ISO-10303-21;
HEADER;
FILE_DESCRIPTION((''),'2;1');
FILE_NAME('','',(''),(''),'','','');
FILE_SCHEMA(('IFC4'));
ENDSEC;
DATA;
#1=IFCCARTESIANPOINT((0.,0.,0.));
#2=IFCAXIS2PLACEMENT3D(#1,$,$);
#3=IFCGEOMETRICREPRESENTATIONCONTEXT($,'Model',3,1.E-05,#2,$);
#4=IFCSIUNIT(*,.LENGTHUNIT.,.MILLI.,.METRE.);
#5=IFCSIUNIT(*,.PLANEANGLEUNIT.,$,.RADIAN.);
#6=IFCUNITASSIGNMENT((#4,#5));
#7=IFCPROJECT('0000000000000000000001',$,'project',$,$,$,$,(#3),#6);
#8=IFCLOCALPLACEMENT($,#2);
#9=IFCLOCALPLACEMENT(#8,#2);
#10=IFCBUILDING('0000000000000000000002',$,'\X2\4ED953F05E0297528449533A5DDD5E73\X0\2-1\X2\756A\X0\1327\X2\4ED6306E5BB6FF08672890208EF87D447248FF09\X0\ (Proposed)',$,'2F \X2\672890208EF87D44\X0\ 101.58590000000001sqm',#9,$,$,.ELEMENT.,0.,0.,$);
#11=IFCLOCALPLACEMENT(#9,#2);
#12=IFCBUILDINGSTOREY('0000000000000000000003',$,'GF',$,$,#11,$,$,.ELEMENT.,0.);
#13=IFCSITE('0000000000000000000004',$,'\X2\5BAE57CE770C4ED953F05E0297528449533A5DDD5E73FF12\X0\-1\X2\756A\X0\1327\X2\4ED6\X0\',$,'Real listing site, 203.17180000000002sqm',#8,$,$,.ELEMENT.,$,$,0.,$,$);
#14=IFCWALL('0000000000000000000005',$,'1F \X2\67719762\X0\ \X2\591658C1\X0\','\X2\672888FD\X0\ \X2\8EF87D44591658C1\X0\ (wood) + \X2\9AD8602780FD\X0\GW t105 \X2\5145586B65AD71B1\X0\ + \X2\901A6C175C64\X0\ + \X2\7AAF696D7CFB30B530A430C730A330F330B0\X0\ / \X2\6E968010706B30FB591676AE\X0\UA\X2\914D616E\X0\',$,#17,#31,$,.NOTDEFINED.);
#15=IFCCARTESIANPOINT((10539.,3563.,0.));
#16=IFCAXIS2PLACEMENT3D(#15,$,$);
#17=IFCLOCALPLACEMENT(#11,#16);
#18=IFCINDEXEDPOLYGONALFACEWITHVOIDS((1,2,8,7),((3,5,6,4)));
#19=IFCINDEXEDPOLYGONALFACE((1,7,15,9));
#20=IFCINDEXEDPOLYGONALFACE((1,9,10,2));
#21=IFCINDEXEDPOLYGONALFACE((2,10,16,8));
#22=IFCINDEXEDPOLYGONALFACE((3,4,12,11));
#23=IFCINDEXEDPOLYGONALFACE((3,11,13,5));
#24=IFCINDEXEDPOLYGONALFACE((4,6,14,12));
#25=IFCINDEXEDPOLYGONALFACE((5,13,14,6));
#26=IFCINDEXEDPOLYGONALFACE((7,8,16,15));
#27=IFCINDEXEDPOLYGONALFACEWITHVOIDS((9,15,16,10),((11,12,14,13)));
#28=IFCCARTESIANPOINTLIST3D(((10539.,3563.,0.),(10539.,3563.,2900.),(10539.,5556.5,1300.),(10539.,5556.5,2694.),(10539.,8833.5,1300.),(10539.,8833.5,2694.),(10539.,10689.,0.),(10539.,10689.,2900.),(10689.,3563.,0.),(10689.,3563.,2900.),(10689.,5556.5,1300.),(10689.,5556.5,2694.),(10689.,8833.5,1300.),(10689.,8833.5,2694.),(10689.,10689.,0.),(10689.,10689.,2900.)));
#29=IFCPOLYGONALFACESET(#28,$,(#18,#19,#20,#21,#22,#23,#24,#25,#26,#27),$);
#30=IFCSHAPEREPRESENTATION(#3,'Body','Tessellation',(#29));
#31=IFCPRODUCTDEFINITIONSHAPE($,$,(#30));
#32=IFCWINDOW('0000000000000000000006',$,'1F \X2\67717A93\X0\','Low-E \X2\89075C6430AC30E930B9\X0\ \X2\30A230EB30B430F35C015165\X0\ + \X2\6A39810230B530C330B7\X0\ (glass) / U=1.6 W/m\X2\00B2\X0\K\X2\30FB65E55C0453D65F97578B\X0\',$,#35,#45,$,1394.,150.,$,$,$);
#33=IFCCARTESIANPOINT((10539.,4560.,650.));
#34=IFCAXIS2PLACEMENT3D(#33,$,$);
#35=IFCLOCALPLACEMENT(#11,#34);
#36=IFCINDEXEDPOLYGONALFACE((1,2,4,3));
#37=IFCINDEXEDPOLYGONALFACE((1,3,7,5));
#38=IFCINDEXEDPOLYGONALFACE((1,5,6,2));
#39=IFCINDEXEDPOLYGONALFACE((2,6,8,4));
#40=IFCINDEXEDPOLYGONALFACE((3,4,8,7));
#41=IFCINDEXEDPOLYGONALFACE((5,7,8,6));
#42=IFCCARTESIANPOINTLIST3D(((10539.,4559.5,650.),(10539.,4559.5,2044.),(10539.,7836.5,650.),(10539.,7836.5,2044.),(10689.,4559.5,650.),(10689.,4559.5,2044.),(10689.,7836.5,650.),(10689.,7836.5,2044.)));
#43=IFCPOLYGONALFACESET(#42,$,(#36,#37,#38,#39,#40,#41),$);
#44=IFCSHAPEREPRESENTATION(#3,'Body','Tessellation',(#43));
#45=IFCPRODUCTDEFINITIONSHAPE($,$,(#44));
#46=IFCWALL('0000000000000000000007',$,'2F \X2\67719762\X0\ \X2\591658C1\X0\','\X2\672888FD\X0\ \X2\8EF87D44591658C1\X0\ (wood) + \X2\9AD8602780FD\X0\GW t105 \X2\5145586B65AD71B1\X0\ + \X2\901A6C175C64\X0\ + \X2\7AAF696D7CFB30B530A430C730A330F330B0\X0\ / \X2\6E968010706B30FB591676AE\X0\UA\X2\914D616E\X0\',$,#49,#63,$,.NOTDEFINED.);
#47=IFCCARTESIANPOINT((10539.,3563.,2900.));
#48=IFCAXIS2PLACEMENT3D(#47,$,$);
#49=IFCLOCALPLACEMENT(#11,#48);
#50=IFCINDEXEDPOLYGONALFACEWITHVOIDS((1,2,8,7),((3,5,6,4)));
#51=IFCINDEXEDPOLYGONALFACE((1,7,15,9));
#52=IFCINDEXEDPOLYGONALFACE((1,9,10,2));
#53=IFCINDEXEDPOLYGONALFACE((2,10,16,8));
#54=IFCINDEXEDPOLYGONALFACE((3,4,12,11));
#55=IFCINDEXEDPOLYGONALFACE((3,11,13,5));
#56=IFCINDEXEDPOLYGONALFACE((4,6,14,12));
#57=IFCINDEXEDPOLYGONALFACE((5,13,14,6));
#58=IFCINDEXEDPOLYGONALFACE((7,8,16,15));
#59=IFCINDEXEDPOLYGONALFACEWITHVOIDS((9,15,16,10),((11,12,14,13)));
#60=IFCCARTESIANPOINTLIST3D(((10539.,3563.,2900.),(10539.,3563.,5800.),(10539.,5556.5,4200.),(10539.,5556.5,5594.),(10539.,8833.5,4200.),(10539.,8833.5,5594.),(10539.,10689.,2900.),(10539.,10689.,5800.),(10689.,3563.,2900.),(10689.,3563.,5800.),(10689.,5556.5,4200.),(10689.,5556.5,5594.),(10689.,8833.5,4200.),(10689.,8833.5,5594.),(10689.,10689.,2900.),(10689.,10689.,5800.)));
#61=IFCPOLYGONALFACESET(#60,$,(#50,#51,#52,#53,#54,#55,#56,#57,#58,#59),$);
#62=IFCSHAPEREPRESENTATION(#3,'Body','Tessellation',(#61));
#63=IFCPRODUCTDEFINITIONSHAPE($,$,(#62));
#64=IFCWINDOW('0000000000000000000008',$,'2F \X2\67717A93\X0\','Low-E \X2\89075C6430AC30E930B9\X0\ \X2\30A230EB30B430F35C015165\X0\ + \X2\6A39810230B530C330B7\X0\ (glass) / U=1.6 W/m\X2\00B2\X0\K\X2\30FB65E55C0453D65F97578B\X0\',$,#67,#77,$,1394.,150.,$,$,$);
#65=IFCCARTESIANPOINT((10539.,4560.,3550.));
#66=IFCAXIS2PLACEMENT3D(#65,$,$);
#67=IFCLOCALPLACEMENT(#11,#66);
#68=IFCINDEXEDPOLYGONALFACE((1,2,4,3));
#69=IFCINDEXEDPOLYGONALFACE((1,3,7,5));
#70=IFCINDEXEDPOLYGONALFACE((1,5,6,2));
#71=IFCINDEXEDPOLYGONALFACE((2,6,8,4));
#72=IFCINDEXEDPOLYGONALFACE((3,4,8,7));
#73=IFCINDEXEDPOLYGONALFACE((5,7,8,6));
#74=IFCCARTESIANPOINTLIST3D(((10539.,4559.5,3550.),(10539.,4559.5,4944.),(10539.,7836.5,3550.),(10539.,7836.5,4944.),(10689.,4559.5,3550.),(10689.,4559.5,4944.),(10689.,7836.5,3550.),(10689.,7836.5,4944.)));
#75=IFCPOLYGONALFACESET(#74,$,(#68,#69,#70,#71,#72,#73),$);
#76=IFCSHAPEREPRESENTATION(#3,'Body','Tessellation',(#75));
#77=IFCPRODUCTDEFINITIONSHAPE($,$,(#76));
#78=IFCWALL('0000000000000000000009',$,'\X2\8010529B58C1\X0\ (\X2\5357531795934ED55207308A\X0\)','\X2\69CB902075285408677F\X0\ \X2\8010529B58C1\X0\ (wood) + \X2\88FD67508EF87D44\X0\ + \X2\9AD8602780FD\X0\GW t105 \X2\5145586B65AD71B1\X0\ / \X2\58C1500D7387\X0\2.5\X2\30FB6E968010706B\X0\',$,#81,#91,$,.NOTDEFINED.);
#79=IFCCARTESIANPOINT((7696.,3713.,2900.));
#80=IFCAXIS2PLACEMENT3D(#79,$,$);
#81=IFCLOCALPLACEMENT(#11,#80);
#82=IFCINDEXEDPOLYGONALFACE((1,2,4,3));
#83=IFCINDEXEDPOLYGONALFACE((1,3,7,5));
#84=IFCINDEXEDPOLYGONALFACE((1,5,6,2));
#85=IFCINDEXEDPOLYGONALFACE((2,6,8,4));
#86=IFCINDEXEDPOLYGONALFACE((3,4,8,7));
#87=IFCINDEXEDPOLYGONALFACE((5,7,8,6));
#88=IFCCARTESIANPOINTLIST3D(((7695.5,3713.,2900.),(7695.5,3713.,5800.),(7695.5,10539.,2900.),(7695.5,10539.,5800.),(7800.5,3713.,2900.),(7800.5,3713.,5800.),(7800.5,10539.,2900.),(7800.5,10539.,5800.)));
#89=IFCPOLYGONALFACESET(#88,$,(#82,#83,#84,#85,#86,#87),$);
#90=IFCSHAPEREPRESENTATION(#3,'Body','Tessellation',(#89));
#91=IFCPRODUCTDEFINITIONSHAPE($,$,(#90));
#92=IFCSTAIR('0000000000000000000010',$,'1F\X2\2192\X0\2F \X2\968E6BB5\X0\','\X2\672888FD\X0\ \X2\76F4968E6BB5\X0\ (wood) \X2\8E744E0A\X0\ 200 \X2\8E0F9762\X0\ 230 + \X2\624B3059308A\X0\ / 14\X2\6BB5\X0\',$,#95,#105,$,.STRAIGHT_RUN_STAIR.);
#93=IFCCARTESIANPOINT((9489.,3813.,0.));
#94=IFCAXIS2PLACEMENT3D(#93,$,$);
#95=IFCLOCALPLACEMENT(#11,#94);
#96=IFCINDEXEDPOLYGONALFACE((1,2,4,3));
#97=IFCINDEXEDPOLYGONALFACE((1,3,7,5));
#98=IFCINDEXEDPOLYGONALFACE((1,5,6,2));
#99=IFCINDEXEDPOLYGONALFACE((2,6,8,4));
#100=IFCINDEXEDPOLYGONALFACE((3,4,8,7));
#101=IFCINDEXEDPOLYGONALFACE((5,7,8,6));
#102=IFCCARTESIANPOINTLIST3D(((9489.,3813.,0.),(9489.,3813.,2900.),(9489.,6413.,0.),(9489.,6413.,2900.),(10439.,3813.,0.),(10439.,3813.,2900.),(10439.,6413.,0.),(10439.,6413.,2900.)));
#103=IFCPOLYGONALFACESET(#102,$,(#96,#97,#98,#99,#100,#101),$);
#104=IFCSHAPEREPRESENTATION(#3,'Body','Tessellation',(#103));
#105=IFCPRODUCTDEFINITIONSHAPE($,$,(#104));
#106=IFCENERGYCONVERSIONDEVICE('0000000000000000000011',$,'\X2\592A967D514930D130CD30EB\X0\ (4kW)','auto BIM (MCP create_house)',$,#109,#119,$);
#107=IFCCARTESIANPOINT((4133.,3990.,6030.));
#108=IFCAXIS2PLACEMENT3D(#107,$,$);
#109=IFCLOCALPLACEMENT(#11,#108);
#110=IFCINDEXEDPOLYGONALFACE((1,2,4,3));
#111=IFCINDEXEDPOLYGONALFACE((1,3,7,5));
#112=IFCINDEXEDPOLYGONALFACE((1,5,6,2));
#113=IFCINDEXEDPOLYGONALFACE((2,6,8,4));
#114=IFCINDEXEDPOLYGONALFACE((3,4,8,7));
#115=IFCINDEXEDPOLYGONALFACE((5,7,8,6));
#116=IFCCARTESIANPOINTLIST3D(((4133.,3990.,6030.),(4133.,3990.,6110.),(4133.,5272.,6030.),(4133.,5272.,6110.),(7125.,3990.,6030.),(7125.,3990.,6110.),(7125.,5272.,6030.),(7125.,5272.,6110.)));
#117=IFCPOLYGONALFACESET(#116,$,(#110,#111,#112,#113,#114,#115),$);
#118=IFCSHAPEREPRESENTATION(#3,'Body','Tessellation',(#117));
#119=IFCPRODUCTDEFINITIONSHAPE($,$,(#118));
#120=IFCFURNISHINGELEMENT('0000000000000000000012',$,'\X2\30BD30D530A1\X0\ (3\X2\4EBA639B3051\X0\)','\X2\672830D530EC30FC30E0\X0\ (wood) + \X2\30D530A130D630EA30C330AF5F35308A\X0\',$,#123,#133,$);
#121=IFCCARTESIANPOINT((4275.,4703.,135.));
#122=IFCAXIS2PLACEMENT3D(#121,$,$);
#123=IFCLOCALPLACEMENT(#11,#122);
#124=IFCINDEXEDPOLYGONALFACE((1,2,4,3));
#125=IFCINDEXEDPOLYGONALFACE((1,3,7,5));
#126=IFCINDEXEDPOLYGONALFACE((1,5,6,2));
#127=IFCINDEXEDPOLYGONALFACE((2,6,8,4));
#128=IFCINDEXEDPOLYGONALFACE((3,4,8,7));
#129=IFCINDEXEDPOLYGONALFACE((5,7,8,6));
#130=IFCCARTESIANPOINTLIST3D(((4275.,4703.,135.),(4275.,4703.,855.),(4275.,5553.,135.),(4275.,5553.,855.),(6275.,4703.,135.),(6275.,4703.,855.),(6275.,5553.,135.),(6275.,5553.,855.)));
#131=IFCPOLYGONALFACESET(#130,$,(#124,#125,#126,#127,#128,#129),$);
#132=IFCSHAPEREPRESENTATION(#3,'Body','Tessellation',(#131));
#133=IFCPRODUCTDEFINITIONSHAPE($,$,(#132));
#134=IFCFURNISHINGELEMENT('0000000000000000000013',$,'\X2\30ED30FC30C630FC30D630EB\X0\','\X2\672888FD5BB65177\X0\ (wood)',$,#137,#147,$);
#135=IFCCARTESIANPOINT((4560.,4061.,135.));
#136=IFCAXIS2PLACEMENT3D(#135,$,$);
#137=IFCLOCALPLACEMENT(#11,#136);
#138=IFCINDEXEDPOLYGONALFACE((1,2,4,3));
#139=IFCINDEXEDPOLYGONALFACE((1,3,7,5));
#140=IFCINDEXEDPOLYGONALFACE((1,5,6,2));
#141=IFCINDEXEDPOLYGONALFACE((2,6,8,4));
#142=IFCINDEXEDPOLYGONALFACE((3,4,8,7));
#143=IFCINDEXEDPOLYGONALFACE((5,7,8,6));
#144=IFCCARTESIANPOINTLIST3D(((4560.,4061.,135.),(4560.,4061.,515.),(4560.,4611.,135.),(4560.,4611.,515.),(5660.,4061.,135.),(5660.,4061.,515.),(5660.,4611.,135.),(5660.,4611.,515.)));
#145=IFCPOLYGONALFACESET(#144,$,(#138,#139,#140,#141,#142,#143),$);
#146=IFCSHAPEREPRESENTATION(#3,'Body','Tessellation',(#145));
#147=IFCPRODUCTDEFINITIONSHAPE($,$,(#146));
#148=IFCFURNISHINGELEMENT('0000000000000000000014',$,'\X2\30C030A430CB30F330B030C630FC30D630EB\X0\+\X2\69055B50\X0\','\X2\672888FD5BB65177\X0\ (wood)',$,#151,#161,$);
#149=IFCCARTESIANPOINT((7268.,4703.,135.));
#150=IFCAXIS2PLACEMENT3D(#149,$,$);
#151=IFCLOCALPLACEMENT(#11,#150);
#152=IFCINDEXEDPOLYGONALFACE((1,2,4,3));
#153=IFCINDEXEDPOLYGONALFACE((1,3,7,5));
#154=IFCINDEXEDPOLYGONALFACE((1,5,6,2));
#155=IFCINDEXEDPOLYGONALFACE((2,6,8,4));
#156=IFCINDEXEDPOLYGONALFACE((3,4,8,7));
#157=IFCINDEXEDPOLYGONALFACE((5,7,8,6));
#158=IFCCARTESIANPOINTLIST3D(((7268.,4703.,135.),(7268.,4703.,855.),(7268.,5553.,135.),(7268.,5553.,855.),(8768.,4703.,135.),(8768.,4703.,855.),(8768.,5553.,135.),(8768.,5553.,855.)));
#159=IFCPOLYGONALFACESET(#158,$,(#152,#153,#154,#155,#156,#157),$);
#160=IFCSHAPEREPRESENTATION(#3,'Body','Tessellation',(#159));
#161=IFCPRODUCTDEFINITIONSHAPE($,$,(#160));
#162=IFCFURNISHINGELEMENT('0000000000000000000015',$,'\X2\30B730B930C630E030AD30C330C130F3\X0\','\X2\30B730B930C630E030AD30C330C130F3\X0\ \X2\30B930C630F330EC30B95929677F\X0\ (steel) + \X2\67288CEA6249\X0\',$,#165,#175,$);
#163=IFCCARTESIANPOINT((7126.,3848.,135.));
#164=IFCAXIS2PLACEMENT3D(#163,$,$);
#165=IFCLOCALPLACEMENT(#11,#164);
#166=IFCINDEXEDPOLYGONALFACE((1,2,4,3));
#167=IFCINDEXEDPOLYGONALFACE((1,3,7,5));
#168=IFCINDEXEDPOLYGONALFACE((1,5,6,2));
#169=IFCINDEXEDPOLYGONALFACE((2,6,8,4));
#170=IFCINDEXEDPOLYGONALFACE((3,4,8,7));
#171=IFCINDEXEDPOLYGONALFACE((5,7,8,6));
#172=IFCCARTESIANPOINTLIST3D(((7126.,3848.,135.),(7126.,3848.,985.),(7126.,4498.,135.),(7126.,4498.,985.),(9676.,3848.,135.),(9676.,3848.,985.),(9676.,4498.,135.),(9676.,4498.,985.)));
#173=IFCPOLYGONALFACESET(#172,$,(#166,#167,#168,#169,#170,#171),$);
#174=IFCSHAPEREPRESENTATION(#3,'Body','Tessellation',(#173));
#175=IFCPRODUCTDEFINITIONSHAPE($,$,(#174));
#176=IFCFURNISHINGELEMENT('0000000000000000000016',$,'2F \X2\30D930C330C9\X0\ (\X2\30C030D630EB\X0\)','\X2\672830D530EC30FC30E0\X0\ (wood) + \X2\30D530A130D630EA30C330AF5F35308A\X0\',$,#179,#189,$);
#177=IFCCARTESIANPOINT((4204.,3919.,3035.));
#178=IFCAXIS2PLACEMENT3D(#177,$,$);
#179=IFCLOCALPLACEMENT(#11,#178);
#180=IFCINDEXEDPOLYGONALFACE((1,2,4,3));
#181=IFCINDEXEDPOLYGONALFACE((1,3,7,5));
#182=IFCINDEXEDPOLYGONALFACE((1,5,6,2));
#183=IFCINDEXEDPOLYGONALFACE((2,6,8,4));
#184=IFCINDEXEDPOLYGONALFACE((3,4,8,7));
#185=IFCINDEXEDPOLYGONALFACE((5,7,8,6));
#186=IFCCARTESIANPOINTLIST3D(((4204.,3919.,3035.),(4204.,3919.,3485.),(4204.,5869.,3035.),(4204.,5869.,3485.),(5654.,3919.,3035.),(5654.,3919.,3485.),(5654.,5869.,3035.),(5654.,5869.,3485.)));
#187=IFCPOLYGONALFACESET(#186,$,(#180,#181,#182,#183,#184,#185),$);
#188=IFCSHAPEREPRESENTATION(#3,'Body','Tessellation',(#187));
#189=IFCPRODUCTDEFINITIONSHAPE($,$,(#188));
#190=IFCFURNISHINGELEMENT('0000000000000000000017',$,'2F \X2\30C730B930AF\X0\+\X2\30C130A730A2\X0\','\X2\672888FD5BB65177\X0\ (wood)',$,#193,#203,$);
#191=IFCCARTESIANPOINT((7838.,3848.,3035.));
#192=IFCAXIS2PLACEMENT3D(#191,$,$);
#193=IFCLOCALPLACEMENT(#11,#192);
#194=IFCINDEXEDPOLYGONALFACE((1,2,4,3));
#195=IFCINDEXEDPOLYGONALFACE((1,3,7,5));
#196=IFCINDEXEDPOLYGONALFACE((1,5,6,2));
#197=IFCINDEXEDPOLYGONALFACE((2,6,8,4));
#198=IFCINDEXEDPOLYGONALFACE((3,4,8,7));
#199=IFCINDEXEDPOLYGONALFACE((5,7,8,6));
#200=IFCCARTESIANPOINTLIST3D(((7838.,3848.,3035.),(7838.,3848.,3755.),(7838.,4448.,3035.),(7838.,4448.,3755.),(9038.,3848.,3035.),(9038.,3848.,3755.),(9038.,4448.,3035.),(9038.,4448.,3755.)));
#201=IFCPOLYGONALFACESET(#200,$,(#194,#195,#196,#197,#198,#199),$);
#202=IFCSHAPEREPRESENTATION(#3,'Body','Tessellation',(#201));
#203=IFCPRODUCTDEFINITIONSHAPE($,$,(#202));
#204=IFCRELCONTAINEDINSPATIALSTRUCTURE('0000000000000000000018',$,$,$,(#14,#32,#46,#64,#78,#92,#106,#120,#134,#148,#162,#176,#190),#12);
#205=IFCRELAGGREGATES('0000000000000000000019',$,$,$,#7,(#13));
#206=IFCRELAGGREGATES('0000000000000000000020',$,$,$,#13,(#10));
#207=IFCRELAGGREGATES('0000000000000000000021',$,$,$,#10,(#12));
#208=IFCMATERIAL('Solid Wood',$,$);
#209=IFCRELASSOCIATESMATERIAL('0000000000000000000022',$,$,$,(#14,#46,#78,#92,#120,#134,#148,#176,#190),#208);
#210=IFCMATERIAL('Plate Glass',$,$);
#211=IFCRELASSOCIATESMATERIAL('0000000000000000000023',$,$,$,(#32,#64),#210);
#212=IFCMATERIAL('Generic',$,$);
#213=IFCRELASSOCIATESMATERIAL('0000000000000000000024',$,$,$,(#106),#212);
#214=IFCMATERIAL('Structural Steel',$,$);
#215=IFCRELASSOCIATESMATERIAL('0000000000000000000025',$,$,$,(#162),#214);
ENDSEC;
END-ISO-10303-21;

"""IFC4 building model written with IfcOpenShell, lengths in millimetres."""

from ifc_helpers import new_model, si_unit, frame, frame_2d, origin, place, context, project, spatial, rectangle, extrude, material, element, fill, save


model = new_model("IFC4")

# Units and contexts
model_context = context("Model", 3, precision=1e-05, world=origin())
ifc_project = project(units=[si_unit("LENGTHUNIT", "METRE", prefix="MILLI"), si_unit("PLANEANGLEUNIT", "RADIAN")], contexts=[model_context])

# Site, building, storey
site_placement = place(None, origin())
site = spatial("IfcSite", under=ifc_project, at=site_placement, Name="宮城県仙台市青葉区川平２-1番1327他", ObjectType="Real listing site, 203.17180000000002sqm", CompositionType="ELEMENT", RefElevation=0.0)
building_placement = place(site_placement, origin())
building = spatial("IfcBuilding", under=site, at=building_placement, Name="仙台市青葉区川平2-1番1327他の家（木造軸組版） (Proposed)", ObjectType="2F 木造軸組 101.58590000000001sqm", CompositionType="ELEMENT", ElevationOfRefHeight=0.0, ElevationOfTerrain=0.0)
storey_placement = place(building_placement, origin())
storey = spatial("IfcBuildingStorey", under=building, at=storey_placement, Name="GF", CompositionType="ELEMENT", Elevation=0.0)

# Wall, opening, window
ifc_material_1 = material(Name="Solid Wood")
wall_1_placement = place(storey_placement, frame((10539.0, 3563.0, 0.0)))
wall_1 = element("IfcWall", 1, at=wall_1_placement, inside=storey, material=ifc_material_1, Name="1F 東面 外壁", Description="木製 軸組外壁 (wood) + 高性能GW t105 充填断熱 + 通気層 + 窯業系サイディング / 準耐火・外皮UA配慮", PredefinedType="NOTDEFINED", context=model_context, shape_type="SweptSolid", body=[
    extrude(rectangle(XDim=150.0, YDim=7126.0, at=frame_2d((75.0, 3563.0))), frame((10539.0, 3563.0, 0.0)), (0.0, 0.0, 1.0), 2900.0),
])
opening_1_placement = place(storey_placement, frame((10539.0, 4560.0, 650.0)))
opening_1 = element("IfcOpeningElement", 2, at=opening_1_placement, cuts=wall_1, PredefinedType="NOTDEFINED", context=model_context, shape_type="SweptSolid", body=[
    extrude(rectangle(XDim=150.0, YDim=3277.0, at=frame_2d((75.0, 1638.0))), frame((10539.0, 4560.0, 650.0)), (0.0, 0.0, 1.0), 1394.0),
])
ifc_material_2 = material(Name="Plate Glass")
window_1_placement = place(storey_placement, frame((10539.0, 4560.0, 650.0)))
window_1 = element("IfcWindow", 3, at=window_1_placement, inside=storey, material=ifc_material_2, Name="1F 東窓", Description="Low-E 複層ガラス アルゴン封入 + 樹脂サッシ (glass) / U=1.6 W/m²K・日射取得型", OverallHeight=1394.0, OverallWidth=150.0, context=model_context, shape_type="SweptSolid", body=[
    extrude(rectangle(XDim=150.0, YDim=3277.0, at=frame_2d((75.0, 1638.0))), frame((10539.0, 4560.0, 650.0)), (0.0, 0.0, 1.0), 1394.0),
])
fill(opening_1, window_1)

# Wall, opening, window
wall_2_placement = place(storey_placement, frame((10539.0, 3563.0, 2900.0)))
wall_2 = element("IfcWall", 4, at=wall_2_placement, inside=storey, material=ifc_material_1, Name="2F 東面 外壁", Description="木製 軸組外壁 (wood) + 高性能GW t105 充填断熱 + 通気層 + 窯業系サイディング / 準耐火・外皮UA配慮", PredefinedType="NOTDEFINED", context=model_context, shape_type="SweptSolid", body=[
    extrude(rectangle(XDim=150.0, YDim=7126.0, at=frame_2d((75.0, 3563.0))), frame((10539.0, 3563.0, 2900.0)), (0.0, 0.0, 1.0), 2900.0),
])
opening_2_placement = place(storey_placement, frame((10539.0, 4560.0, 3550.0)))
opening_2 = element("IfcOpeningElement", 5, at=opening_2_placement, cuts=wall_2, PredefinedType="NOTDEFINED", context=model_context, shape_type="SweptSolid", body=[
    extrude(rectangle(XDim=150.0, YDim=3277.0, at=frame_2d((75.0, 1638.0))), frame((10539.0, 4560.0, 3550.0)), (0.0, 0.0, 1.0), 1394.0),
])
window_2_placement = place(storey_placement, frame((10539.0, 4560.0, 3550.0)))
window_2 = element("IfcWindow", 6, at=window_2_placement, inside=storey, material=ifc_material_2, Name="2F 東窓", Description="Low-E 複層ガラス アルゴン封入 + 樹脂サッシ (glass) / U=1.6 W/m²K・日射取得型", OverallHeight=1394.0, OverallWidth=150.0, context=model_context, shape_type="SweptSolid", body=[
    extrude(rectangle(XDim=150.0, YDim=3277.0, at=frame_2d((75.0, 1638.0))), frame((10539.0, 4560.0, 3550.0)), (0.0, 0.0, 1.0), 1394.0),
])
fill(opening_2, window_2)

# Wall
wall_3_placement = place(storey_placement, frame((7696.0, 3713.0, 2900.0)))
element("IfcWall", 7, at=wall_3_placement, inside=storey, material=ifc_material_1, Name="耐力壁 (南北間仕切り)", Description="構造用合板 耐力壁 (wood) + 製材軸組 + 高性能GW t105 充填断熱 / 壁倍率2.5・準耐火", PredefinedType="NOTDEFINED", context=model_context, shape_type="SweptSolid", body=[
    extrude(rectangle(XDim=105.0, YDim=6826.0, at=frame_2d((52.0, 3413.0))), frame((7696.0, 3713.0, 2900.0)), (0.0, 0.0, 1.0), 2900.0),
])

# Stair
stair_placement = place(storey_placement, frame((9489.0, 3813.0, 0.0)))
element("IfcStair", 8, at=stair_placement, inside=storey, material=ifc_material_1, Name="1F→2F 階段", Description="木製 直階段 (wood) 蹴上 200 踏面 230 + 手すり / 14段", PredefinedType="STRAIGHT_RUN_STAIR", context=model_context, shape_type="SweptSolid", body=[
    extrude(rectangle(XDim=950.0, YDim=2600.0, at=frame_2d((475.0, 1300.0))), frame((9489.0, 3813.0, 0.0)), (0.0, 0.0, 1.0), 2900.0),
])

# Energy conversion device
ifc_material_3 = material(Name="Generic")
energy_conversion_device_placement = place(storey_placement, frame((4133.0, 3990.0, 6030.0)))
element("IfcEnergyConversionDevice", 9, at=energy_conversion_device_placement, inside=storey, material=ifc_material_3, Name="太陽光パネル (4kW)", Description="auto BIM (MCP create_house)", context=model_context, shape_type="SweptSolid", body=[
    extrude(rectangle(XDim=2992.0, YDim=1282.0, at=frame_2d((1496.0, 641.0))), frame((4133.0, 3990.0, 6030.0)), (0.0, 0.0, 1.0), 80.0),
])

# Furnishing elements
furnishing_1_placement = place(storey_placement, frame((4275.0, 4703.0, 135.0)))
element("IfcFurnishingElement", 10, at=furnishing_1_placement, inside=storey, material=ifc_material_1, Name="ソファ (3人掛け)", Description="木フレーム (wood) + ファブリック張り", context=model_context, shape_type="SweptSolid", body=[
    extrude(rectangle(XDim=2000.0, YDim=850.0, at=frame_2d((1000.0, 425.0))), frame((4275.0, 4703.0, 135.0)), (0.0, 0.0, 1.0), 720.0),
])
furnishing_2_placement = place(storey_placement, frame((4560.0, 4061.0, 135.0)))
element("IfcFurnishingElement", 11, at=furnishing_2_placement, inside=storey, material=ifc_material_1, Name="ローテーブル", Description="木製家具 (wood)", context=model_context, shape_type="SweptSolid", body=[
    extrude(rectangle(XDim=1100.0, YDim=550.0, at=frame_2d((550.0, 275.0))), frame((4560.0, 4061.0, 135.0)), (0.0, 0.0, 1.0), 380.0),
])
furnishing_3_placement = place(storey_placement, frame((7268.0, 4703.0, 135.0)))
element("IfcFurnishingElement", 12, at=furnishing_3_placement, inside=storey, material=ifc_material_1, Name="ダイニングテーブル+椅子", Description="木製家具 (wood)", context=model_context, shape_type="SweptSolid", body=[
    extrude(rectangle(XDim=1500.0, YDim=850.0, at=frame_2d((750.0, 425.0))), frame((7268.0, 4703.0, 135.0)), (0.0, 0.0, 1.0), 720.0),
])
ifc_material_4 = material(Name="Structural Steel")
furnishing_4_placement = place(storey_placement, frame((7126.0, 3848.0, 135.0)))
element("IfcFurnishingElement", 13, at=furnishing_4_placement, inside=storey, material=ifc_material_4, Name="システムキッチン", Description="システムキッチン ステンレス天板 (steel) + 木質扉", context=model_context, shape_type="SweptSolid", body=[
    extrude(rectangle(XDim=2550.0, YDim=650.0, at=frame_2d((1275.0, 325.0))), frame((7126.0, 3848.0, 135.0)), (0.0, 0.0, 1.0), 850.0),
])
furnishing_5_placement = place(storey_placement, frame((4204.0, 3919.0, 3035.0)))
element("IfcFurnishingElement", 14, at=furnishing_5_placement, inside=storey, material=ifc_material_1, Name="2F ベッド (ダブル)", Description="木フレーム (wood) + ファブリック張り", context=model_context, shape_type="SweptSolid", body=[
    extrude(rectangle(XDim=1450.0, YDim=1950.0, at=frame_2d((725.0, 975.0))), frame((4204.0, 3919.0, 3035.0)), (0.0, 0.0, 1.0), 450.0),
])
furnishing_6_placement = place(storey_placement, frame((7838.0, 3848.0, 3035.0)))
element("IfcFurnishingElement", 15, at=furnishing_6_placement, inside=storey, material=ifc_material_1, Name="2F デスク+チェア", Description="木製家具 (wood)", context=model_context, shape_type="SweptSolid", body=[
    extrude(rectangle(XDim=1200.0, YDim=600.0, at=frame_2d((600.0, 300.0))), frame((7838.0, 3848.0, 3035.0)), (0.0, 0.0, 1.0), 720.0),
])

save(model, "model.ifc")
